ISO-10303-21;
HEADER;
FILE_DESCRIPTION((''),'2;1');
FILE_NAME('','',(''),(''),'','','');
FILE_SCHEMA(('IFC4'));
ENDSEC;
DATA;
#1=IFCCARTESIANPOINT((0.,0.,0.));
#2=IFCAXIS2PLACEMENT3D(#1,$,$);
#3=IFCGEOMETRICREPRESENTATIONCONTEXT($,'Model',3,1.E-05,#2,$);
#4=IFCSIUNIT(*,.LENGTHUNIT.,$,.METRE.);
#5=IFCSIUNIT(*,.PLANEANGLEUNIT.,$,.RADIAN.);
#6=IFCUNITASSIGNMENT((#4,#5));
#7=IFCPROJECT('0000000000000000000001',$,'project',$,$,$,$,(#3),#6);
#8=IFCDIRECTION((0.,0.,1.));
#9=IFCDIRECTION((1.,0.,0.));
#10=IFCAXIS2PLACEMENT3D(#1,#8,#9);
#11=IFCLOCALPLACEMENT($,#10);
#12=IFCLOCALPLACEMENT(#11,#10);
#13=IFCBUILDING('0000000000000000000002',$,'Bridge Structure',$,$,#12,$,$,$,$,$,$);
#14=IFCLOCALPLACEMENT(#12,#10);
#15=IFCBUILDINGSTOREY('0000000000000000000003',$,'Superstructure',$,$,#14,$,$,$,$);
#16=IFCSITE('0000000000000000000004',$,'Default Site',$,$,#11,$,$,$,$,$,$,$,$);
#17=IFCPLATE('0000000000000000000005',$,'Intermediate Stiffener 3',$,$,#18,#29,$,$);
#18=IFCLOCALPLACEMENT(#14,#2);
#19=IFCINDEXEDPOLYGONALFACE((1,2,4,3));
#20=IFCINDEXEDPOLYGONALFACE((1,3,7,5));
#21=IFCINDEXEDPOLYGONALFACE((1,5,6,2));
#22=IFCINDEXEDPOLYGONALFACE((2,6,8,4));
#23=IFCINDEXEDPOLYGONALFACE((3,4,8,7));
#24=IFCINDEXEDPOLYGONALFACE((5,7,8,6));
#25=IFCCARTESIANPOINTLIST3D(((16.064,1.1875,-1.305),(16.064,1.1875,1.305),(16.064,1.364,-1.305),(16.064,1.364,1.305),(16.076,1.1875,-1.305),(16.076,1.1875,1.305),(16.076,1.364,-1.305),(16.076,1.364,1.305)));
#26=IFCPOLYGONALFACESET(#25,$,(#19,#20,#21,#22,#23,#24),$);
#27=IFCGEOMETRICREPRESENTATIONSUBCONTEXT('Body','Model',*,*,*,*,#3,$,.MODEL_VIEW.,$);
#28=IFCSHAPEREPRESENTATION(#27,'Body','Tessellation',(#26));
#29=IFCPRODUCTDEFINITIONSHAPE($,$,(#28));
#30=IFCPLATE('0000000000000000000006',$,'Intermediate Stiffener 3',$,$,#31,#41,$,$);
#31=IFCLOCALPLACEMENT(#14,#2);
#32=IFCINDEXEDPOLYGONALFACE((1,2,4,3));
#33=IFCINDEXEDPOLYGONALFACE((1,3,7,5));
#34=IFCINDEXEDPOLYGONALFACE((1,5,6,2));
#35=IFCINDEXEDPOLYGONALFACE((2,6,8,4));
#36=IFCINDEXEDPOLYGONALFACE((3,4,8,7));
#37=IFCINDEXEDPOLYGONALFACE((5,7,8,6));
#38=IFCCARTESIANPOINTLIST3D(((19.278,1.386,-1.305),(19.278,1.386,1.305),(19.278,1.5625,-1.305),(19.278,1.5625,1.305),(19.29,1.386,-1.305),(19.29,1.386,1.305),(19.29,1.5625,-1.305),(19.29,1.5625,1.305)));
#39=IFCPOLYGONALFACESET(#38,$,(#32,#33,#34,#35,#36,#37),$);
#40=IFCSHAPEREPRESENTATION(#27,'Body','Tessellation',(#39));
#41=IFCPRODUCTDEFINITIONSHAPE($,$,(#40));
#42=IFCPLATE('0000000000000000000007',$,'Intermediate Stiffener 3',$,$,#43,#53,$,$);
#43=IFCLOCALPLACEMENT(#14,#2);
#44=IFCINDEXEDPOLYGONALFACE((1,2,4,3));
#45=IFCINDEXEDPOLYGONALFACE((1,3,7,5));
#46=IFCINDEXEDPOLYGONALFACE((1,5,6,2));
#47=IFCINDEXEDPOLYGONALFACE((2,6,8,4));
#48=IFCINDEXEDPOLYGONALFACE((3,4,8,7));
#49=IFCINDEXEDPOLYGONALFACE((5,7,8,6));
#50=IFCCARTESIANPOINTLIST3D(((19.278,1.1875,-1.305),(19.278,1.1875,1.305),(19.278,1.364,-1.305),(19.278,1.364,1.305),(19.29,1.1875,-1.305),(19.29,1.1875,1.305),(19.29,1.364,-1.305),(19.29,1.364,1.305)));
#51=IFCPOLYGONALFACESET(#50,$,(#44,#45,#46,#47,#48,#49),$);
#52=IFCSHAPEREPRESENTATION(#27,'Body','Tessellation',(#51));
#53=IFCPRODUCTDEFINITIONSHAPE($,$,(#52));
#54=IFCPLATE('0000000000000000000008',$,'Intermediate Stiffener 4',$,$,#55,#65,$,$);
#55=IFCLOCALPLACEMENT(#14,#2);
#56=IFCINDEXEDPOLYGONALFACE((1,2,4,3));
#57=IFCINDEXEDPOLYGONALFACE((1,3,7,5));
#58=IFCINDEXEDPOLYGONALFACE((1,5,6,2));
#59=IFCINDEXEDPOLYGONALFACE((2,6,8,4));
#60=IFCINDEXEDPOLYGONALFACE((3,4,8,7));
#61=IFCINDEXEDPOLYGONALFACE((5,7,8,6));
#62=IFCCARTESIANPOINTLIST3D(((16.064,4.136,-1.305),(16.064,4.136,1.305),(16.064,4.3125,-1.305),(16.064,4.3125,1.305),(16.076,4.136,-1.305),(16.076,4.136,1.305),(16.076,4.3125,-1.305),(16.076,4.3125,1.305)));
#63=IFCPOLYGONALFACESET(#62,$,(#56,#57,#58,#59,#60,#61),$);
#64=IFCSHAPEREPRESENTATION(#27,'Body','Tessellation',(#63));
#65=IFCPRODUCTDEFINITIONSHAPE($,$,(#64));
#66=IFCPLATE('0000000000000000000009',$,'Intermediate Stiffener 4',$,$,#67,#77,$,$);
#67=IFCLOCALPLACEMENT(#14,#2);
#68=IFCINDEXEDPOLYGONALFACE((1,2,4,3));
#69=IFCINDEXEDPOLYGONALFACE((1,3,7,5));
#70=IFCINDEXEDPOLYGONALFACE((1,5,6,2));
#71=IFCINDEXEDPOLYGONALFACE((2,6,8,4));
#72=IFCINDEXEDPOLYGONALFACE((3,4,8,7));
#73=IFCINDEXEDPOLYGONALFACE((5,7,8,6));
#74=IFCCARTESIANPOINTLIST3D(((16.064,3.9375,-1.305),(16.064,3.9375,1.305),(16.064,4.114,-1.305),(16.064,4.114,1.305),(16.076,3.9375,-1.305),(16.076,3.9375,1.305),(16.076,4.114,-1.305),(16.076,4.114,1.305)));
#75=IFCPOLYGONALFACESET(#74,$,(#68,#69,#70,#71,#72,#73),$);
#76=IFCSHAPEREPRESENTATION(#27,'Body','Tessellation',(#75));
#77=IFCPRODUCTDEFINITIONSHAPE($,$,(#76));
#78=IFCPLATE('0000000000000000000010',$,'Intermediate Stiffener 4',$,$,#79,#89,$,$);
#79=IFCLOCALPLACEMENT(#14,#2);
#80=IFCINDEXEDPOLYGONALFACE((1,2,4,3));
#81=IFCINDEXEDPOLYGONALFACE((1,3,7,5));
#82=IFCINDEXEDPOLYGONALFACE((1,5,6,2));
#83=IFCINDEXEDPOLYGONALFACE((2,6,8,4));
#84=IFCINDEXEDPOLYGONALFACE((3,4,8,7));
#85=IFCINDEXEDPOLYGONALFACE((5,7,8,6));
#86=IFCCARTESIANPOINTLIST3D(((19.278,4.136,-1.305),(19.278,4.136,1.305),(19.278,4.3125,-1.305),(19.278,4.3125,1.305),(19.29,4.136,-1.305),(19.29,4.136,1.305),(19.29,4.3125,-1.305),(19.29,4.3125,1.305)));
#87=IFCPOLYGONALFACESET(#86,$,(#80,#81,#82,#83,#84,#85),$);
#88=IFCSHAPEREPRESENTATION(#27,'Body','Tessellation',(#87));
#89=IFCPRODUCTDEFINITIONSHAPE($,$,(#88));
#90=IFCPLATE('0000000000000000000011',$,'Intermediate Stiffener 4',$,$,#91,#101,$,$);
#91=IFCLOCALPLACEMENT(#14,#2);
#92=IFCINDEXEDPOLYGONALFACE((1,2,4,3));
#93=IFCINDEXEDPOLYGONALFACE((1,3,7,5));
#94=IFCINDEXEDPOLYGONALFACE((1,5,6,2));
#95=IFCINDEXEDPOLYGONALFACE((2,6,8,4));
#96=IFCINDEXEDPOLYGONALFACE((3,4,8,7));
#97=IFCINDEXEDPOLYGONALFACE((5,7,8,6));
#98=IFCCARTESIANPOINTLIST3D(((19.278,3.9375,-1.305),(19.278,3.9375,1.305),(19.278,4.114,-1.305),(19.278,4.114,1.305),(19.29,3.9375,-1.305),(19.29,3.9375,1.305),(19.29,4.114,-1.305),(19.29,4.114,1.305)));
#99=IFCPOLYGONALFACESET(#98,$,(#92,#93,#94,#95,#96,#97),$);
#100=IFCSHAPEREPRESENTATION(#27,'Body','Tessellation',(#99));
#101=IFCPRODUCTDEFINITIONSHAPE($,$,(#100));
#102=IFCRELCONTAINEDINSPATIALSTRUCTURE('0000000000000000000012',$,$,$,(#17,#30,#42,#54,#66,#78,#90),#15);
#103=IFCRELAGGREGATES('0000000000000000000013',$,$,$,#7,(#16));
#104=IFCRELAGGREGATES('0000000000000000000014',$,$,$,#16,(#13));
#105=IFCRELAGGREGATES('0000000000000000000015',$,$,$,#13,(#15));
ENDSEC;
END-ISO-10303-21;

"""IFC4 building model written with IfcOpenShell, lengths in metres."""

from ifc_helpers import new_model, si_unit, frame, origin, origin_with_axes, origin_2d_with_axis, place, context, subcontext, project, spatial, rectangle, extrude, element, save


model = new_model("IFC4")

# Units and contexts
model_context = context("Model", 3, precision=1e-05, world=origin())
body_context = subcontext(model_context, "Body", "Model", "MODEL_VIEW")
ifc_project = project(units=[si_unit("LENGTHUNIT", "METRE"), si_unit("PLANEANGLEUNIT", "RADIAN")], contexts=[model_context])

# Site, building, storey
site_placement = place(None, origin_with_axes())
site = spatial("IfcSite", under=ifc_project, at=site_placement, Name="Default Site")
building_placement = place(site_placement, origin_with_axes())
building = spatial("IfcBuilding", under=site, at=building_placement, Name="Bridge Structure")
storey_placement = place(building_placement, origin_with_axes())
storey = spatial("IfcBuildingStorey", under=building, at=storey_placement, Name="Superstructure")

# Plates
for number, where, z_axis, x_axis, name in (
    (1, (16.07, 1.2757, -1.305), (0.0, 0.0, 1.0), (1.0, 0.0, 0.0), "Intermediate Stiffener 3"),
    (2, (19.284, 1.4743, -1.305), (0.0, 0.0, 1.0), (1.0, 0.0, 0.0), "Intermediate Stiffener 3"),
    (3, (19.284, 1.2757, -1.305), (0.0, 0.0, 1.0), (1.0, 0.0, 0.0), "Intermediate Stiffener 3"),
    (4, (16.07, 4.2243, -1.305), (0.0, 0.0, 1.0), (1.0, 0.0, 0.0), "Intermediate Stiffener 4"),
    (5, (16.07, 4.0258, -1.305), (0.0, 0.0, 1.0), (1.0, 0.0, 0.0), "Intermediate Stiffener 4"),
    (6, (19.284, 4.2243, -1.305), (0.0, 0.0, 1.0), (1.0, 0.0, 0.0), "Intermediate Stiffener 4"),
    (7, (19.284, 4.0258, -1.305), (0.0, 0.0, 1.0), (1.0, 0.0, 0.0), "Intermediate Stiffener 4"),
):
    element("IfcPlate", number, at=place(storey_placement, frame(where, z_axis=z_axis, x_axis=x_axis)), inside=storey, Name=name, context=body_context, shape_type="SweptSolid", body=[
        extrude(rectangle(XDim=0.012, YDim=0.1765, at=origin_2d_with_axis()), origin_with_axes(), (0.0, 0.0, 1.0), 2.61),
    ])

save(model, "model.ifc")
